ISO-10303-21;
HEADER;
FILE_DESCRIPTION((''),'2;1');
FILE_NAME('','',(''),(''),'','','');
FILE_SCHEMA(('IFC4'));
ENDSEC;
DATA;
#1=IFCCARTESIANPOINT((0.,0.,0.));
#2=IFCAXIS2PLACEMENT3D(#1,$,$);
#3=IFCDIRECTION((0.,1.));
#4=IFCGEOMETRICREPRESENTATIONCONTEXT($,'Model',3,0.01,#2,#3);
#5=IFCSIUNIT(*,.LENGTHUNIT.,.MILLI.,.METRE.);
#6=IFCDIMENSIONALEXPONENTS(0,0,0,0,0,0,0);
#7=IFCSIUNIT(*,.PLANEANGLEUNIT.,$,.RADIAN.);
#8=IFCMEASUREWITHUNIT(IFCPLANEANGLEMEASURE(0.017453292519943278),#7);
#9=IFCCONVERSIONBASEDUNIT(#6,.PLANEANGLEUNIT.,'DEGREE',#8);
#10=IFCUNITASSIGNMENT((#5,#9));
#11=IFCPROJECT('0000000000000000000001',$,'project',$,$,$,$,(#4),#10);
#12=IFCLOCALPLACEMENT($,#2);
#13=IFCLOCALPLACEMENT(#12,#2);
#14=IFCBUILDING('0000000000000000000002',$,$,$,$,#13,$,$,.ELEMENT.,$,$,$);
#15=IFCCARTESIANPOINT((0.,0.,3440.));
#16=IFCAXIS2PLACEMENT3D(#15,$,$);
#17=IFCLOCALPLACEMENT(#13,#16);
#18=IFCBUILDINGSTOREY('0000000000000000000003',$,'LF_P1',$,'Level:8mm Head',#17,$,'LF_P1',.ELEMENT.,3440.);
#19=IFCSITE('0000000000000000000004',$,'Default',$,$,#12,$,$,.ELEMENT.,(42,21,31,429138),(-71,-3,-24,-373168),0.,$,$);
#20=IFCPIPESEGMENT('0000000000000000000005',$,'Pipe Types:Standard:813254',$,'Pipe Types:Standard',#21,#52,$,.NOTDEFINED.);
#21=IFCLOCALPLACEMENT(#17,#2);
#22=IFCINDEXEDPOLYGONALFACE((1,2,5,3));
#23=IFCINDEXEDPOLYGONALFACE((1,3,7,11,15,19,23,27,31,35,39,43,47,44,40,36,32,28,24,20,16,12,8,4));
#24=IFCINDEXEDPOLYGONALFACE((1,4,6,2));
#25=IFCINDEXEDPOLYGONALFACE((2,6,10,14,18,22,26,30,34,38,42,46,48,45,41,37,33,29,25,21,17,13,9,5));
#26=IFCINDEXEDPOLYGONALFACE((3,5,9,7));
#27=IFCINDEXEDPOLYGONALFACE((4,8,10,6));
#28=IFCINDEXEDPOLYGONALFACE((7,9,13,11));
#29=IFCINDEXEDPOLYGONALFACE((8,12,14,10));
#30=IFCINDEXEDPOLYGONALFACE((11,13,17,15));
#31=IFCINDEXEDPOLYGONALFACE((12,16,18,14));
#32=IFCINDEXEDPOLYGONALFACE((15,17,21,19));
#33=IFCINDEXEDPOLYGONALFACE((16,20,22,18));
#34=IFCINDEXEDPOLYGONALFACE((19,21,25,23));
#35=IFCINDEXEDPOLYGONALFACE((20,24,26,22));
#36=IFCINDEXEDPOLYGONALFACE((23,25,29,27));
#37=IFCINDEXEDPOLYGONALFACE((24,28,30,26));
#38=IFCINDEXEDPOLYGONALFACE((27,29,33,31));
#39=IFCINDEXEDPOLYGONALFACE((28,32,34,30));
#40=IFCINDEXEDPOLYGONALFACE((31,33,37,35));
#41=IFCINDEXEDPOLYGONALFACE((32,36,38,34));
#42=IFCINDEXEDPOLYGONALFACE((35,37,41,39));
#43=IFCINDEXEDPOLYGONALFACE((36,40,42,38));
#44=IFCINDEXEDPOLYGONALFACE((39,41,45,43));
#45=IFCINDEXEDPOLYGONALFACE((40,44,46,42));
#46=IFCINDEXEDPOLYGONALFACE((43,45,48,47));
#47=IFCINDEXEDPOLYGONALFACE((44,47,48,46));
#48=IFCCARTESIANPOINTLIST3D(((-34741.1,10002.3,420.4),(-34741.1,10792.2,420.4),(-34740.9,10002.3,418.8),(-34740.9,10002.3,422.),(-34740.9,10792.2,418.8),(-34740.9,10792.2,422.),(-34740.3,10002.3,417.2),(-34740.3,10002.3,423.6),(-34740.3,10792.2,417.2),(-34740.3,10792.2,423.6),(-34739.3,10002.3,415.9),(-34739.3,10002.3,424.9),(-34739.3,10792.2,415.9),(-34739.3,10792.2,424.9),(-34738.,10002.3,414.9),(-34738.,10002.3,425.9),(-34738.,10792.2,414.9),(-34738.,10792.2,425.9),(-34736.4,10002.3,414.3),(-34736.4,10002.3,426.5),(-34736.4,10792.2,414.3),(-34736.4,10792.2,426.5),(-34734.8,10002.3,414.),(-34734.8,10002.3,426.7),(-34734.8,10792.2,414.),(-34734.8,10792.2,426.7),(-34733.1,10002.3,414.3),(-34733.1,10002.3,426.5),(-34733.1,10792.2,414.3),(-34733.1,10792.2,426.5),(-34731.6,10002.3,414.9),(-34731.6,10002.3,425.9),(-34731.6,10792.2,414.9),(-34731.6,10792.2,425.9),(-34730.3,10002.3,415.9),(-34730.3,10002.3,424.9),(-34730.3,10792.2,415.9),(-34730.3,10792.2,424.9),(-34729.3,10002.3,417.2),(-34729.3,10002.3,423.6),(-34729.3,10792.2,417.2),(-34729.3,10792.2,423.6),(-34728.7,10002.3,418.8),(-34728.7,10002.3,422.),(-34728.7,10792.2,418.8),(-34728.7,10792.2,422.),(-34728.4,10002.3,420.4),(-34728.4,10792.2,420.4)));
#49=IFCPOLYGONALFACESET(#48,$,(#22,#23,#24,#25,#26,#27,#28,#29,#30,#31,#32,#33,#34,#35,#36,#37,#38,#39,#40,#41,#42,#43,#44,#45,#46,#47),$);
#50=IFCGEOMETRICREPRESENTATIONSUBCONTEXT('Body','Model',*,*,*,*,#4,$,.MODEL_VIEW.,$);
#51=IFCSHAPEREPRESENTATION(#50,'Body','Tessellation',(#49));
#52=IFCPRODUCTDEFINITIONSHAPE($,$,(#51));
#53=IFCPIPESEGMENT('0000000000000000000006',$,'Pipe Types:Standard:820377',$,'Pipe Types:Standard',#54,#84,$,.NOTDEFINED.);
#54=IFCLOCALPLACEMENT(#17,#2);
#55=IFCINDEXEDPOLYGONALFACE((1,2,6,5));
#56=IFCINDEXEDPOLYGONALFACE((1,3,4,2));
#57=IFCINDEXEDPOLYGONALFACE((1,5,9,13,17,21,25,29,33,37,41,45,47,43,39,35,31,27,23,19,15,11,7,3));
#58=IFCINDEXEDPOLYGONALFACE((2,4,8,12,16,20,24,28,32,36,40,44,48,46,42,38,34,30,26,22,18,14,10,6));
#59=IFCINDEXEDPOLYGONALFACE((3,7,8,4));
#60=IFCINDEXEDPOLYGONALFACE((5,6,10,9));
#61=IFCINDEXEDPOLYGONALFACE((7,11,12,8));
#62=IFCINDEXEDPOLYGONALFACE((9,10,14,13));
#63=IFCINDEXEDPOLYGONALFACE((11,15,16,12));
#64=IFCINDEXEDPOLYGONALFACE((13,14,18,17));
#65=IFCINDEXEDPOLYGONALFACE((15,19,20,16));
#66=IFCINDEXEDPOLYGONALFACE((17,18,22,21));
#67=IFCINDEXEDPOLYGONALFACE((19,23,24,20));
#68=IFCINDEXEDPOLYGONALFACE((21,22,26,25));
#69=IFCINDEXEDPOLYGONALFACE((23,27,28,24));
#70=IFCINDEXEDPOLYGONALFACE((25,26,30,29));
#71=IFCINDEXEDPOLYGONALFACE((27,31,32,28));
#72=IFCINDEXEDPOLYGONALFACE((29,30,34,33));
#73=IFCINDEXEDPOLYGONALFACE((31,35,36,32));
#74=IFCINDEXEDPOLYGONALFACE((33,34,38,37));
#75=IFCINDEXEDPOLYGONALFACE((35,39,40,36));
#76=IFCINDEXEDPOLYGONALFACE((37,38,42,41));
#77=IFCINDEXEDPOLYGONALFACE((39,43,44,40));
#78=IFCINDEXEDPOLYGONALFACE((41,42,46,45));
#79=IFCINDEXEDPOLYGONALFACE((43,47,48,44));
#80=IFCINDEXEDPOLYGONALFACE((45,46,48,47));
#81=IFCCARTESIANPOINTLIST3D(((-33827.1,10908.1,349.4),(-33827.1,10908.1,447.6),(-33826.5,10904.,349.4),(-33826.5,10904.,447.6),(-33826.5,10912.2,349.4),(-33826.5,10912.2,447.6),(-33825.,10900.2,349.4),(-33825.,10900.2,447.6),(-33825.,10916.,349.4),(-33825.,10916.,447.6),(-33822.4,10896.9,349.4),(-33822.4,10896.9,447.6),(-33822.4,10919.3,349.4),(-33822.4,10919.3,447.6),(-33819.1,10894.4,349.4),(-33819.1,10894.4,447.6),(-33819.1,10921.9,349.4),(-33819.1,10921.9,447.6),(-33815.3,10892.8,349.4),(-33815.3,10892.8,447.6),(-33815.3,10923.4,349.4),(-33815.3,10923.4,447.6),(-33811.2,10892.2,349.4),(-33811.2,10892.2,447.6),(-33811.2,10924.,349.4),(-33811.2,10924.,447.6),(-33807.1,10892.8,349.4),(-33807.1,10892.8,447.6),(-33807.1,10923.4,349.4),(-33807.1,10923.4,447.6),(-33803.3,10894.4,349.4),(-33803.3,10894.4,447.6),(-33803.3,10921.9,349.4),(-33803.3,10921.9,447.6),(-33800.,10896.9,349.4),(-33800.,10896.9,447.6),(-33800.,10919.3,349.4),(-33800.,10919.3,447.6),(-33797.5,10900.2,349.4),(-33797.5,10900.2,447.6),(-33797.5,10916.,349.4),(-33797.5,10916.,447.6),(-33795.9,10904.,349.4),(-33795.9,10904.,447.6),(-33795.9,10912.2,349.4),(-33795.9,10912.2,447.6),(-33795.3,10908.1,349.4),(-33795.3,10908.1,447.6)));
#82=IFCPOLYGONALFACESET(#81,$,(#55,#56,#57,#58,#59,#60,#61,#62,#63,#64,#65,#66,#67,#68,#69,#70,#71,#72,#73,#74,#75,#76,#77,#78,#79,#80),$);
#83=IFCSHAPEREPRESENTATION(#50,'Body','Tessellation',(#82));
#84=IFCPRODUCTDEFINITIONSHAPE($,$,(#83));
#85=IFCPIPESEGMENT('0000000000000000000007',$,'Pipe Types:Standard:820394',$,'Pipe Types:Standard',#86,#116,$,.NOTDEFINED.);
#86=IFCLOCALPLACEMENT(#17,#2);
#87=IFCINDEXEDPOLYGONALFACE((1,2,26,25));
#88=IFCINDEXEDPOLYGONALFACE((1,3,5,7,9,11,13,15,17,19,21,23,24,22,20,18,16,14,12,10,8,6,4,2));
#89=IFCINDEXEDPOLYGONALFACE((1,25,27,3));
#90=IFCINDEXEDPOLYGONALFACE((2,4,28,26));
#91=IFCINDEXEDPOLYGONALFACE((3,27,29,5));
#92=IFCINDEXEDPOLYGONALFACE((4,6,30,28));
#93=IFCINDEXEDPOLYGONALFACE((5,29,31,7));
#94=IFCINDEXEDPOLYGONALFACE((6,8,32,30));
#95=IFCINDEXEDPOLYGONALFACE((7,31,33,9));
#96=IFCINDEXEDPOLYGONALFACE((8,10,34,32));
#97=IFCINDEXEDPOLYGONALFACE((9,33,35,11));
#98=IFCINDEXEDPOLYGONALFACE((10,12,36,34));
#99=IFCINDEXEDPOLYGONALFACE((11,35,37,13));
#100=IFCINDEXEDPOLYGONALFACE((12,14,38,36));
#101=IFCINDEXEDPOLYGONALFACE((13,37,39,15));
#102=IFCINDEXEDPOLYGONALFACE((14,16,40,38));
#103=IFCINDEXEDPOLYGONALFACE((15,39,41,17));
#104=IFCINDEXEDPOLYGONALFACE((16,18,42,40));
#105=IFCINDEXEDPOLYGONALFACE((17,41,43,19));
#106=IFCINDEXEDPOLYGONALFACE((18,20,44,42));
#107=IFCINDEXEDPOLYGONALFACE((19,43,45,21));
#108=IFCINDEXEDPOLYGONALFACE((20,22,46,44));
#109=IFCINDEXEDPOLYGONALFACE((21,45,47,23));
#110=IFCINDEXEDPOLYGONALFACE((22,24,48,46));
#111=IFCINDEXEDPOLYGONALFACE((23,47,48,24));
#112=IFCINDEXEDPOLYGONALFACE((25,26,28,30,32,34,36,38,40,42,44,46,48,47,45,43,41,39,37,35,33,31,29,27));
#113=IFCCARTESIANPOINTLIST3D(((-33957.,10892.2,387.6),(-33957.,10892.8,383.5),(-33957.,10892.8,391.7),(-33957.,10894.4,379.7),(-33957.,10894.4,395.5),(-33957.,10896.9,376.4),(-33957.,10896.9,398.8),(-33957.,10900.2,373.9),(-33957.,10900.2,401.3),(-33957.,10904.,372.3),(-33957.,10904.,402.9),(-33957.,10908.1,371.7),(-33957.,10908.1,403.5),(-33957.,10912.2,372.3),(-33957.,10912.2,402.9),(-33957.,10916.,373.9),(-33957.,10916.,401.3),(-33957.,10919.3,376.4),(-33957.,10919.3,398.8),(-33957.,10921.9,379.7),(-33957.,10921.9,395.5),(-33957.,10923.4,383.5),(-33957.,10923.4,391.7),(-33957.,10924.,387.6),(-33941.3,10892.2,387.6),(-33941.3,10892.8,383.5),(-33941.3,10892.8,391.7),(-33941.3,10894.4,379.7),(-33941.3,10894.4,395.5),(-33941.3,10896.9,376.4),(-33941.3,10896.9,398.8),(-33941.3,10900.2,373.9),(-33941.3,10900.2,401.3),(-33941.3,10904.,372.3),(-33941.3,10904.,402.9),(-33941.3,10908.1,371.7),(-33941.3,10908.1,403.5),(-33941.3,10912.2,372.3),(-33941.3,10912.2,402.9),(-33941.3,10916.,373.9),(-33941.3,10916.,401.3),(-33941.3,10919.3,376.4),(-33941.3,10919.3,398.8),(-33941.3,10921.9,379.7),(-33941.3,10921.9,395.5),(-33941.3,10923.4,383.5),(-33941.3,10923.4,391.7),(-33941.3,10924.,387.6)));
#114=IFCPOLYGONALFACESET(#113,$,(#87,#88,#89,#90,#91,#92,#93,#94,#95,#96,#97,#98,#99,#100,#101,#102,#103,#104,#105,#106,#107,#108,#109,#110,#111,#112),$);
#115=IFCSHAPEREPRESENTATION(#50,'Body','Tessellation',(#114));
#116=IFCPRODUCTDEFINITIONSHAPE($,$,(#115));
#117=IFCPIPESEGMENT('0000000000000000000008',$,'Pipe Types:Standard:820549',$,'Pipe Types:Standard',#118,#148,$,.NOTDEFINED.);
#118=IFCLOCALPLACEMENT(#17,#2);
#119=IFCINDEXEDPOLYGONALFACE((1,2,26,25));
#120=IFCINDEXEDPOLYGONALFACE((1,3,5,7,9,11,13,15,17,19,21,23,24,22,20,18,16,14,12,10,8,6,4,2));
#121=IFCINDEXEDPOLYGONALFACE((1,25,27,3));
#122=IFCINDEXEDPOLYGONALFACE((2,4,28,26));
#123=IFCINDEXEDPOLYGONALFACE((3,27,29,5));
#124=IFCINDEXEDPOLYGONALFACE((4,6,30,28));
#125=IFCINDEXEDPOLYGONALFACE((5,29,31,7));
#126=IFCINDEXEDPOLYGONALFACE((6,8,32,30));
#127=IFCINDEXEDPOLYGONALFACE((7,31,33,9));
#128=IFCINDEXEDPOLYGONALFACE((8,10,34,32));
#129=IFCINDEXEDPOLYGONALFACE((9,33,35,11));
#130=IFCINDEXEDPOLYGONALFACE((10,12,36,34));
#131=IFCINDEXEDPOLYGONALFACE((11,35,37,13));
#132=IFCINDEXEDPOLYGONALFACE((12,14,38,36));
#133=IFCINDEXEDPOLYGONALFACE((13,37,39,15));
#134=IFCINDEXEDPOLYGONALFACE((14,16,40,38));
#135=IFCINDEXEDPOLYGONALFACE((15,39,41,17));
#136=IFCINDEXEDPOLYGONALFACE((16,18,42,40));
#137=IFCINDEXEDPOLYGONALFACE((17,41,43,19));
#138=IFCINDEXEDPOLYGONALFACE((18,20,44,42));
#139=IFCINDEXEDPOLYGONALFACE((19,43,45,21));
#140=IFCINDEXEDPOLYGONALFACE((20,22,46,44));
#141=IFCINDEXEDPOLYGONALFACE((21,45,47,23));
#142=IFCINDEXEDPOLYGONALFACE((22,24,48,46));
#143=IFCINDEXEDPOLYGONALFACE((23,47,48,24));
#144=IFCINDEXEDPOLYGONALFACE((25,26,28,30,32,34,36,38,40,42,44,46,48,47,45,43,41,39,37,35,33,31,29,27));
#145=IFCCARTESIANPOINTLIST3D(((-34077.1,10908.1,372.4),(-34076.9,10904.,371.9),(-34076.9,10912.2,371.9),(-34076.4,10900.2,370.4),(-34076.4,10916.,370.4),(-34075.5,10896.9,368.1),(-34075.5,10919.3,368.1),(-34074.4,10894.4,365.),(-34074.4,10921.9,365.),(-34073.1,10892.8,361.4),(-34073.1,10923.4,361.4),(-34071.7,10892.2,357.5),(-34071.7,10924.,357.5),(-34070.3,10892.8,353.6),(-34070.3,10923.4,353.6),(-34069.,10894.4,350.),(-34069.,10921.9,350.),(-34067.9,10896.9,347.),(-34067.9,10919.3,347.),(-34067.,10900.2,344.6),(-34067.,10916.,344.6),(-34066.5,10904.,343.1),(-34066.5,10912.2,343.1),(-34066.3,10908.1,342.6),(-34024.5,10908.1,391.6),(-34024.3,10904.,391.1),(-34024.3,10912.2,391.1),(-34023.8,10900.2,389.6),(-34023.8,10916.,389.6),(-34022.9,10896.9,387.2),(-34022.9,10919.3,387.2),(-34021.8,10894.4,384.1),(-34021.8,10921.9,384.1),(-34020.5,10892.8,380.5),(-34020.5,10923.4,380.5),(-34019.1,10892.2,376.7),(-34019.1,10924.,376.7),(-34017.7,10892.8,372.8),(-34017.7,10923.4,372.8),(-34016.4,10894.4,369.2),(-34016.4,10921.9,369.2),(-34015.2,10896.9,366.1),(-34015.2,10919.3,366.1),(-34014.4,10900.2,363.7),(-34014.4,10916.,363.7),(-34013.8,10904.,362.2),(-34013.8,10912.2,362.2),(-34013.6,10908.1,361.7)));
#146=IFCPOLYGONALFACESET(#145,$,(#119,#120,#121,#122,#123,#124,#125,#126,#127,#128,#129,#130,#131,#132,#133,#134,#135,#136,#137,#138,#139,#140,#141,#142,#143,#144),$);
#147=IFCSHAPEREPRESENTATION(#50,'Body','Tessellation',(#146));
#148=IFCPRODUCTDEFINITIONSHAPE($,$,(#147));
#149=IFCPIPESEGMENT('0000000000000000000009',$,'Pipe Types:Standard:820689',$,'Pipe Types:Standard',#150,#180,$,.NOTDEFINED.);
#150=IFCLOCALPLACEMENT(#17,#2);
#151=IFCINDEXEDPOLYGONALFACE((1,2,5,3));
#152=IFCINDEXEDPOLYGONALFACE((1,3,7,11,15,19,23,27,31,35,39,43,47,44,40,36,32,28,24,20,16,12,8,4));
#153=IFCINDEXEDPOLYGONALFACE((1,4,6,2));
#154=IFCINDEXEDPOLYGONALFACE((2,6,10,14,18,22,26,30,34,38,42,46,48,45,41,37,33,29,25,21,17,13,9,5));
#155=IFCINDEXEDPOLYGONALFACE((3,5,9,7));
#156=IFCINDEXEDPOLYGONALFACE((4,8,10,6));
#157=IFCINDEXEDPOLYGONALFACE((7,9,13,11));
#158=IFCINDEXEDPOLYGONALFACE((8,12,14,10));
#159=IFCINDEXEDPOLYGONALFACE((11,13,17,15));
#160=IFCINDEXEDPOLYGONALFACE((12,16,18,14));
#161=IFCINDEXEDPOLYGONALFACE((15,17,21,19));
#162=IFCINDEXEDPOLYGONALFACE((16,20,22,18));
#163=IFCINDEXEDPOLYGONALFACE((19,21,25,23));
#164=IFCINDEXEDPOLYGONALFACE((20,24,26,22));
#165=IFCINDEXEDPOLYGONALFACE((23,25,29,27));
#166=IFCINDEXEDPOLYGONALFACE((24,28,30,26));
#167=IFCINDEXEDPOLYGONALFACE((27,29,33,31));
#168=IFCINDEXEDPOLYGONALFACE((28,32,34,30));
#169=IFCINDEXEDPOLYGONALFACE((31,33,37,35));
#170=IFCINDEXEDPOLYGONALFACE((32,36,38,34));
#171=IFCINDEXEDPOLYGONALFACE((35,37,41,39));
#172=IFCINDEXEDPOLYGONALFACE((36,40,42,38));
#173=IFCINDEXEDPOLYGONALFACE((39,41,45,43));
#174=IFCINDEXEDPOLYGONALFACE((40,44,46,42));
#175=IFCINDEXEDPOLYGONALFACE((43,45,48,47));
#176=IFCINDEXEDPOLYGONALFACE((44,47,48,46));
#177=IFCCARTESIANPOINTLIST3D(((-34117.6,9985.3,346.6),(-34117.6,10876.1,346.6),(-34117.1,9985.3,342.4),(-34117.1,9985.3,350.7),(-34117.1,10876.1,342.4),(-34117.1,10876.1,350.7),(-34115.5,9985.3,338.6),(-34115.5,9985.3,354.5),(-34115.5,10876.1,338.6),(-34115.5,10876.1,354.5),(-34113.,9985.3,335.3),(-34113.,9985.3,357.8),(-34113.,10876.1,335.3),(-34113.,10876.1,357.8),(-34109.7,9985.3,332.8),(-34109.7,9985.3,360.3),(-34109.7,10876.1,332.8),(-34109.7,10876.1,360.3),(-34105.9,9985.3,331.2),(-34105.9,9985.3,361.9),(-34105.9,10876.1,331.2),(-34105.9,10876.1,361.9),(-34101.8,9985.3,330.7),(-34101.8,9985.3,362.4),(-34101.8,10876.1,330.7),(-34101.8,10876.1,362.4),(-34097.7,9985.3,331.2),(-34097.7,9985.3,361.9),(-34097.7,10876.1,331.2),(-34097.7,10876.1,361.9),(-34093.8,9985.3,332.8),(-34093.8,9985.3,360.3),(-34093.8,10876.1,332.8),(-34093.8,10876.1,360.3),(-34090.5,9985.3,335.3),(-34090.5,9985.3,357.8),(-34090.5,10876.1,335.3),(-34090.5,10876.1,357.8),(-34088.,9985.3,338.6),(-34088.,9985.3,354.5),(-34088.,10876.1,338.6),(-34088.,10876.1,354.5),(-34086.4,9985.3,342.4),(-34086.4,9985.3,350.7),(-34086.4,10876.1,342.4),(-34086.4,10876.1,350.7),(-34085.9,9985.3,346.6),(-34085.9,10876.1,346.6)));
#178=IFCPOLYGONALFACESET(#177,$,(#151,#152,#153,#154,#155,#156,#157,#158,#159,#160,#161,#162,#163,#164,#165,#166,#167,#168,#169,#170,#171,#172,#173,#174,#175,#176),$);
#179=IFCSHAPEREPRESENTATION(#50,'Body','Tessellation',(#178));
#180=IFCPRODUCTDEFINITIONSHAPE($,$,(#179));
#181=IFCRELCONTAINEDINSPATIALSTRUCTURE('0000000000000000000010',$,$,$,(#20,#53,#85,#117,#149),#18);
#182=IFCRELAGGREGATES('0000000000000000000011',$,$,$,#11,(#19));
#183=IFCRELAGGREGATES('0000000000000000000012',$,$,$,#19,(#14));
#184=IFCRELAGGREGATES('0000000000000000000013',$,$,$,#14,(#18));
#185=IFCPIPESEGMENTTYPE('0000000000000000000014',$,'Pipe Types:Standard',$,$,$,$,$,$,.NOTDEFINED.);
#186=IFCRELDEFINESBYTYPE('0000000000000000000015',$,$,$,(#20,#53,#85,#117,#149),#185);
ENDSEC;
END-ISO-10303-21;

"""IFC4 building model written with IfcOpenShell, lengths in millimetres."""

from ifc_helpers import new_model, entity, si_unit, converted_unit, direction, frame, origin, place, context, subcontext, project, spatial, arc, indexed_curve, outline, extrude, type_object, element, save


model = new_model("IFC4")

# Units and contexts
model_context = context("Model", 3, precision=0.01, world=origin(), true_north=direction((0.0, 1.0)))
body_context = subcontext(model_context, "Body", "Model", "MODEL_VIEW")
ifc_project = project(units=[si_unit("LENGTHUNIT", "METRE", prefix="MILLI"), converted_unit("PLANEANGLEUNIT", "DEGREE", entity("IfcPlaneAngleMeasure", 0.017453292519943278), si_unit("PLANEANGLEUNIT", "RADIAN"), dimensions=[0, 0, 0, 0, 0, 0, 0])], contexts=[model_context])

# Site, building, storey
site_placement = place(None, origin())
site = spatial("IfcSite", under=ifc_project, at=site_placement, Name="Default", CompositionType="ELEMENT", RefLatitude=(42, 21, 31, 429138), RefLongitude=(-71, -3, -24, -373168), RefElevation=0.0)
building_placement = place(site_placement, origin())
building = spatial("IfcBuilding", under=site, at=building_placement, CompositionType="ELEMENT")
storey_placement = place(building_placement, frame((0.0, 0.0, 3440.0)))
storey = spatial("IfcBuildingStorey", under=building, at=storey_placement, Name="LF_P1", ObjectType="Level:8mm Head", LongName="LF_P1", CompositionType="ELEMENT", Elevation=3440.0)

# Pipe segments
pipe_segment_type_1 = type_object("IfcPipeSegmentType", Name="Pipe Types:Standard", PredefinedType="NOTDEFINED")
pipe_segment_1_placement = place(storey_placement, origin())
element("IfcPipeSegment", 1, at=pipe_segment_1_placement, inside=storey, type_object=pipe_segment_type_1, Name="Pipe Types:Standard:813254", ObjectType="Pipe Types:Standard", PredefinedType="NOTDEFINED", context=body_context, shape_type="SweptSolid", body=[
    extrude(outline(indexed_curve([(6.4, 0.0), (4.5, 4.5), (0.0, 6.4), (-4.5, 4.5), (-6.3, 0.0), (-4.5, -4.5), (0.0, -6.3), (4.5, -4.5)], segments=[arc(1, 2, 3), arc(3, 4, 5), arc(5, 6, 7), arc(7, 8, 1)], self_intersect=False)), frame((-34734.8, 10002.3, 420.4), z_axis=(0.0, 1.0, 0.0), x_axis=(-1.0, 0.0, 0.0)), (0.0, 0.0, 1.0), 789.9),
])
pipe_segment_2_placement = place(storey_placement, origin())
element("IfcPipeSegment", 2, at=pipe_segment_2_placement, inside=storey, type_object=pipe_segment_type_1, Name="Pipe Types:Standard:820377", ObjectType="Pipe Types:Standard", PredefinedType="NOTDEFINED", context=body_context, shape_type="SweptSolid", body=[
    extrude(outline(indexed_curve([(15.9, 0.0), (11.2, 11.2), (0.0, 15.9), (-11.2, 11.2), (-15.9, 0.0), (-11.2, -11.2), (0.0, -15.9), (11.2, -11.2)], segments=[arc(1, 2, 3), arc(3, 4, 5), arc(5, 6, 7), arc(7, 8, 1)], self_intersect=False)), frame((-33811.2, 10908.1, 349.4)), (0.0, 0.0, 1.0), 98.2),
])
pipe_segment_3_placement = place(storey_placement, origin())
element("IfcPipeSegment", 3, at=pipe_segment_3_placement, inside=storey, type_object=pipe_segment_type_1, Name="Pipe Types:Standard:820394", ObjectType="Pipe Types:Standard", PredefinedType="NOTDEFINED", context=body_context, shape_type="SweptSolid", body=[
    extrude(outline(indexed_curve([(15.9, 0.0), (11.2, 11.2), (0.0, 15.9), (-11.2, 11.2), (-15.9, 0.0), (-11.2, -11.2), (0.0, -15.9), (11.2, -11.2)], segments=[arc(1, 2, 3), arc(3, 4, 5), arc(5, 6, 7), arc(7, 8, 1)], self_intersect=False)), frame((-33957.0, 10908.1, 387.6), z_axis=(1.0, 0.0, 0.0), x_axis=(0.0, -1.0, 0.0)), (0.0, 0.0, 1.0), 15.7),
])
pipe_segment_4_placement = place(storey_placement, origin())
element("IfcPipeSegment", 4, at=pipe_segment_4_placement, inside=storey, type_object=pipe_segment_type_1, Name="Pipe Types:Standard:820549", ObjectType="Pipe Types:Standard", PredefinedType="NOTDEFINED", context=body_context, shape_type="SweptSolid", body=[
    extrude(outline(indexed_curve([(15.9, 0.0), (11.2, 11.2), (0.0, 15.9), (-11.2, 11.2), (-15.9, 0.0), (-11.2, -11.2), (0.0, -15.9), (11.2, -11.2)], segments=[arc(1, 2, 3), arc(3, 4, 5), arc(5, 6, 7), arc(7, 8, 1)], self_intersect=False)), frame((-34071.7, 10908.1, 357.5), z_axis=(0.939693, 0.0, 0.34202), x_axis=(0.0, 1.0, 0.0)), (0.0, 0.0, 1.0), 56.0),
])
pipe_segment_5_placement = place(storey_placement, origin())
element("IfcPipeSegment", 5, at=pipe_segment_5_placement, inside=storey, type_object=pipe_segment_type_1, Name="Pipe Types:Standard:820689", ObjectType="Pipe Types:Standard", PredefinedType="NOTDEFINED", context=body_context, shape_type="SweptSolid", body=[
    extrude(outline(indexed_curve([(15.9, 0.0), (11.2, 11.2), (0.0, 15.9), (-11.2, 11.2), (-15.9, 0.0), (-11.2, -11.2), (0.0, -15.9), (11.2, -11.2)], segments=[arc(1, 2, 3), arc(3, 4, 5), arc(5, 6, 7), arc(7, 8, 1)], self_intersect=False)), frame((-34101.8, 9985.3, 346.6), z_axis=(0.0, 1.0, 0.0), x_axis=(-1.0, 0.0, 0.0)), (0.0, 0.0, 1.0), 890.8),
])

save(model, "model.ifc")
